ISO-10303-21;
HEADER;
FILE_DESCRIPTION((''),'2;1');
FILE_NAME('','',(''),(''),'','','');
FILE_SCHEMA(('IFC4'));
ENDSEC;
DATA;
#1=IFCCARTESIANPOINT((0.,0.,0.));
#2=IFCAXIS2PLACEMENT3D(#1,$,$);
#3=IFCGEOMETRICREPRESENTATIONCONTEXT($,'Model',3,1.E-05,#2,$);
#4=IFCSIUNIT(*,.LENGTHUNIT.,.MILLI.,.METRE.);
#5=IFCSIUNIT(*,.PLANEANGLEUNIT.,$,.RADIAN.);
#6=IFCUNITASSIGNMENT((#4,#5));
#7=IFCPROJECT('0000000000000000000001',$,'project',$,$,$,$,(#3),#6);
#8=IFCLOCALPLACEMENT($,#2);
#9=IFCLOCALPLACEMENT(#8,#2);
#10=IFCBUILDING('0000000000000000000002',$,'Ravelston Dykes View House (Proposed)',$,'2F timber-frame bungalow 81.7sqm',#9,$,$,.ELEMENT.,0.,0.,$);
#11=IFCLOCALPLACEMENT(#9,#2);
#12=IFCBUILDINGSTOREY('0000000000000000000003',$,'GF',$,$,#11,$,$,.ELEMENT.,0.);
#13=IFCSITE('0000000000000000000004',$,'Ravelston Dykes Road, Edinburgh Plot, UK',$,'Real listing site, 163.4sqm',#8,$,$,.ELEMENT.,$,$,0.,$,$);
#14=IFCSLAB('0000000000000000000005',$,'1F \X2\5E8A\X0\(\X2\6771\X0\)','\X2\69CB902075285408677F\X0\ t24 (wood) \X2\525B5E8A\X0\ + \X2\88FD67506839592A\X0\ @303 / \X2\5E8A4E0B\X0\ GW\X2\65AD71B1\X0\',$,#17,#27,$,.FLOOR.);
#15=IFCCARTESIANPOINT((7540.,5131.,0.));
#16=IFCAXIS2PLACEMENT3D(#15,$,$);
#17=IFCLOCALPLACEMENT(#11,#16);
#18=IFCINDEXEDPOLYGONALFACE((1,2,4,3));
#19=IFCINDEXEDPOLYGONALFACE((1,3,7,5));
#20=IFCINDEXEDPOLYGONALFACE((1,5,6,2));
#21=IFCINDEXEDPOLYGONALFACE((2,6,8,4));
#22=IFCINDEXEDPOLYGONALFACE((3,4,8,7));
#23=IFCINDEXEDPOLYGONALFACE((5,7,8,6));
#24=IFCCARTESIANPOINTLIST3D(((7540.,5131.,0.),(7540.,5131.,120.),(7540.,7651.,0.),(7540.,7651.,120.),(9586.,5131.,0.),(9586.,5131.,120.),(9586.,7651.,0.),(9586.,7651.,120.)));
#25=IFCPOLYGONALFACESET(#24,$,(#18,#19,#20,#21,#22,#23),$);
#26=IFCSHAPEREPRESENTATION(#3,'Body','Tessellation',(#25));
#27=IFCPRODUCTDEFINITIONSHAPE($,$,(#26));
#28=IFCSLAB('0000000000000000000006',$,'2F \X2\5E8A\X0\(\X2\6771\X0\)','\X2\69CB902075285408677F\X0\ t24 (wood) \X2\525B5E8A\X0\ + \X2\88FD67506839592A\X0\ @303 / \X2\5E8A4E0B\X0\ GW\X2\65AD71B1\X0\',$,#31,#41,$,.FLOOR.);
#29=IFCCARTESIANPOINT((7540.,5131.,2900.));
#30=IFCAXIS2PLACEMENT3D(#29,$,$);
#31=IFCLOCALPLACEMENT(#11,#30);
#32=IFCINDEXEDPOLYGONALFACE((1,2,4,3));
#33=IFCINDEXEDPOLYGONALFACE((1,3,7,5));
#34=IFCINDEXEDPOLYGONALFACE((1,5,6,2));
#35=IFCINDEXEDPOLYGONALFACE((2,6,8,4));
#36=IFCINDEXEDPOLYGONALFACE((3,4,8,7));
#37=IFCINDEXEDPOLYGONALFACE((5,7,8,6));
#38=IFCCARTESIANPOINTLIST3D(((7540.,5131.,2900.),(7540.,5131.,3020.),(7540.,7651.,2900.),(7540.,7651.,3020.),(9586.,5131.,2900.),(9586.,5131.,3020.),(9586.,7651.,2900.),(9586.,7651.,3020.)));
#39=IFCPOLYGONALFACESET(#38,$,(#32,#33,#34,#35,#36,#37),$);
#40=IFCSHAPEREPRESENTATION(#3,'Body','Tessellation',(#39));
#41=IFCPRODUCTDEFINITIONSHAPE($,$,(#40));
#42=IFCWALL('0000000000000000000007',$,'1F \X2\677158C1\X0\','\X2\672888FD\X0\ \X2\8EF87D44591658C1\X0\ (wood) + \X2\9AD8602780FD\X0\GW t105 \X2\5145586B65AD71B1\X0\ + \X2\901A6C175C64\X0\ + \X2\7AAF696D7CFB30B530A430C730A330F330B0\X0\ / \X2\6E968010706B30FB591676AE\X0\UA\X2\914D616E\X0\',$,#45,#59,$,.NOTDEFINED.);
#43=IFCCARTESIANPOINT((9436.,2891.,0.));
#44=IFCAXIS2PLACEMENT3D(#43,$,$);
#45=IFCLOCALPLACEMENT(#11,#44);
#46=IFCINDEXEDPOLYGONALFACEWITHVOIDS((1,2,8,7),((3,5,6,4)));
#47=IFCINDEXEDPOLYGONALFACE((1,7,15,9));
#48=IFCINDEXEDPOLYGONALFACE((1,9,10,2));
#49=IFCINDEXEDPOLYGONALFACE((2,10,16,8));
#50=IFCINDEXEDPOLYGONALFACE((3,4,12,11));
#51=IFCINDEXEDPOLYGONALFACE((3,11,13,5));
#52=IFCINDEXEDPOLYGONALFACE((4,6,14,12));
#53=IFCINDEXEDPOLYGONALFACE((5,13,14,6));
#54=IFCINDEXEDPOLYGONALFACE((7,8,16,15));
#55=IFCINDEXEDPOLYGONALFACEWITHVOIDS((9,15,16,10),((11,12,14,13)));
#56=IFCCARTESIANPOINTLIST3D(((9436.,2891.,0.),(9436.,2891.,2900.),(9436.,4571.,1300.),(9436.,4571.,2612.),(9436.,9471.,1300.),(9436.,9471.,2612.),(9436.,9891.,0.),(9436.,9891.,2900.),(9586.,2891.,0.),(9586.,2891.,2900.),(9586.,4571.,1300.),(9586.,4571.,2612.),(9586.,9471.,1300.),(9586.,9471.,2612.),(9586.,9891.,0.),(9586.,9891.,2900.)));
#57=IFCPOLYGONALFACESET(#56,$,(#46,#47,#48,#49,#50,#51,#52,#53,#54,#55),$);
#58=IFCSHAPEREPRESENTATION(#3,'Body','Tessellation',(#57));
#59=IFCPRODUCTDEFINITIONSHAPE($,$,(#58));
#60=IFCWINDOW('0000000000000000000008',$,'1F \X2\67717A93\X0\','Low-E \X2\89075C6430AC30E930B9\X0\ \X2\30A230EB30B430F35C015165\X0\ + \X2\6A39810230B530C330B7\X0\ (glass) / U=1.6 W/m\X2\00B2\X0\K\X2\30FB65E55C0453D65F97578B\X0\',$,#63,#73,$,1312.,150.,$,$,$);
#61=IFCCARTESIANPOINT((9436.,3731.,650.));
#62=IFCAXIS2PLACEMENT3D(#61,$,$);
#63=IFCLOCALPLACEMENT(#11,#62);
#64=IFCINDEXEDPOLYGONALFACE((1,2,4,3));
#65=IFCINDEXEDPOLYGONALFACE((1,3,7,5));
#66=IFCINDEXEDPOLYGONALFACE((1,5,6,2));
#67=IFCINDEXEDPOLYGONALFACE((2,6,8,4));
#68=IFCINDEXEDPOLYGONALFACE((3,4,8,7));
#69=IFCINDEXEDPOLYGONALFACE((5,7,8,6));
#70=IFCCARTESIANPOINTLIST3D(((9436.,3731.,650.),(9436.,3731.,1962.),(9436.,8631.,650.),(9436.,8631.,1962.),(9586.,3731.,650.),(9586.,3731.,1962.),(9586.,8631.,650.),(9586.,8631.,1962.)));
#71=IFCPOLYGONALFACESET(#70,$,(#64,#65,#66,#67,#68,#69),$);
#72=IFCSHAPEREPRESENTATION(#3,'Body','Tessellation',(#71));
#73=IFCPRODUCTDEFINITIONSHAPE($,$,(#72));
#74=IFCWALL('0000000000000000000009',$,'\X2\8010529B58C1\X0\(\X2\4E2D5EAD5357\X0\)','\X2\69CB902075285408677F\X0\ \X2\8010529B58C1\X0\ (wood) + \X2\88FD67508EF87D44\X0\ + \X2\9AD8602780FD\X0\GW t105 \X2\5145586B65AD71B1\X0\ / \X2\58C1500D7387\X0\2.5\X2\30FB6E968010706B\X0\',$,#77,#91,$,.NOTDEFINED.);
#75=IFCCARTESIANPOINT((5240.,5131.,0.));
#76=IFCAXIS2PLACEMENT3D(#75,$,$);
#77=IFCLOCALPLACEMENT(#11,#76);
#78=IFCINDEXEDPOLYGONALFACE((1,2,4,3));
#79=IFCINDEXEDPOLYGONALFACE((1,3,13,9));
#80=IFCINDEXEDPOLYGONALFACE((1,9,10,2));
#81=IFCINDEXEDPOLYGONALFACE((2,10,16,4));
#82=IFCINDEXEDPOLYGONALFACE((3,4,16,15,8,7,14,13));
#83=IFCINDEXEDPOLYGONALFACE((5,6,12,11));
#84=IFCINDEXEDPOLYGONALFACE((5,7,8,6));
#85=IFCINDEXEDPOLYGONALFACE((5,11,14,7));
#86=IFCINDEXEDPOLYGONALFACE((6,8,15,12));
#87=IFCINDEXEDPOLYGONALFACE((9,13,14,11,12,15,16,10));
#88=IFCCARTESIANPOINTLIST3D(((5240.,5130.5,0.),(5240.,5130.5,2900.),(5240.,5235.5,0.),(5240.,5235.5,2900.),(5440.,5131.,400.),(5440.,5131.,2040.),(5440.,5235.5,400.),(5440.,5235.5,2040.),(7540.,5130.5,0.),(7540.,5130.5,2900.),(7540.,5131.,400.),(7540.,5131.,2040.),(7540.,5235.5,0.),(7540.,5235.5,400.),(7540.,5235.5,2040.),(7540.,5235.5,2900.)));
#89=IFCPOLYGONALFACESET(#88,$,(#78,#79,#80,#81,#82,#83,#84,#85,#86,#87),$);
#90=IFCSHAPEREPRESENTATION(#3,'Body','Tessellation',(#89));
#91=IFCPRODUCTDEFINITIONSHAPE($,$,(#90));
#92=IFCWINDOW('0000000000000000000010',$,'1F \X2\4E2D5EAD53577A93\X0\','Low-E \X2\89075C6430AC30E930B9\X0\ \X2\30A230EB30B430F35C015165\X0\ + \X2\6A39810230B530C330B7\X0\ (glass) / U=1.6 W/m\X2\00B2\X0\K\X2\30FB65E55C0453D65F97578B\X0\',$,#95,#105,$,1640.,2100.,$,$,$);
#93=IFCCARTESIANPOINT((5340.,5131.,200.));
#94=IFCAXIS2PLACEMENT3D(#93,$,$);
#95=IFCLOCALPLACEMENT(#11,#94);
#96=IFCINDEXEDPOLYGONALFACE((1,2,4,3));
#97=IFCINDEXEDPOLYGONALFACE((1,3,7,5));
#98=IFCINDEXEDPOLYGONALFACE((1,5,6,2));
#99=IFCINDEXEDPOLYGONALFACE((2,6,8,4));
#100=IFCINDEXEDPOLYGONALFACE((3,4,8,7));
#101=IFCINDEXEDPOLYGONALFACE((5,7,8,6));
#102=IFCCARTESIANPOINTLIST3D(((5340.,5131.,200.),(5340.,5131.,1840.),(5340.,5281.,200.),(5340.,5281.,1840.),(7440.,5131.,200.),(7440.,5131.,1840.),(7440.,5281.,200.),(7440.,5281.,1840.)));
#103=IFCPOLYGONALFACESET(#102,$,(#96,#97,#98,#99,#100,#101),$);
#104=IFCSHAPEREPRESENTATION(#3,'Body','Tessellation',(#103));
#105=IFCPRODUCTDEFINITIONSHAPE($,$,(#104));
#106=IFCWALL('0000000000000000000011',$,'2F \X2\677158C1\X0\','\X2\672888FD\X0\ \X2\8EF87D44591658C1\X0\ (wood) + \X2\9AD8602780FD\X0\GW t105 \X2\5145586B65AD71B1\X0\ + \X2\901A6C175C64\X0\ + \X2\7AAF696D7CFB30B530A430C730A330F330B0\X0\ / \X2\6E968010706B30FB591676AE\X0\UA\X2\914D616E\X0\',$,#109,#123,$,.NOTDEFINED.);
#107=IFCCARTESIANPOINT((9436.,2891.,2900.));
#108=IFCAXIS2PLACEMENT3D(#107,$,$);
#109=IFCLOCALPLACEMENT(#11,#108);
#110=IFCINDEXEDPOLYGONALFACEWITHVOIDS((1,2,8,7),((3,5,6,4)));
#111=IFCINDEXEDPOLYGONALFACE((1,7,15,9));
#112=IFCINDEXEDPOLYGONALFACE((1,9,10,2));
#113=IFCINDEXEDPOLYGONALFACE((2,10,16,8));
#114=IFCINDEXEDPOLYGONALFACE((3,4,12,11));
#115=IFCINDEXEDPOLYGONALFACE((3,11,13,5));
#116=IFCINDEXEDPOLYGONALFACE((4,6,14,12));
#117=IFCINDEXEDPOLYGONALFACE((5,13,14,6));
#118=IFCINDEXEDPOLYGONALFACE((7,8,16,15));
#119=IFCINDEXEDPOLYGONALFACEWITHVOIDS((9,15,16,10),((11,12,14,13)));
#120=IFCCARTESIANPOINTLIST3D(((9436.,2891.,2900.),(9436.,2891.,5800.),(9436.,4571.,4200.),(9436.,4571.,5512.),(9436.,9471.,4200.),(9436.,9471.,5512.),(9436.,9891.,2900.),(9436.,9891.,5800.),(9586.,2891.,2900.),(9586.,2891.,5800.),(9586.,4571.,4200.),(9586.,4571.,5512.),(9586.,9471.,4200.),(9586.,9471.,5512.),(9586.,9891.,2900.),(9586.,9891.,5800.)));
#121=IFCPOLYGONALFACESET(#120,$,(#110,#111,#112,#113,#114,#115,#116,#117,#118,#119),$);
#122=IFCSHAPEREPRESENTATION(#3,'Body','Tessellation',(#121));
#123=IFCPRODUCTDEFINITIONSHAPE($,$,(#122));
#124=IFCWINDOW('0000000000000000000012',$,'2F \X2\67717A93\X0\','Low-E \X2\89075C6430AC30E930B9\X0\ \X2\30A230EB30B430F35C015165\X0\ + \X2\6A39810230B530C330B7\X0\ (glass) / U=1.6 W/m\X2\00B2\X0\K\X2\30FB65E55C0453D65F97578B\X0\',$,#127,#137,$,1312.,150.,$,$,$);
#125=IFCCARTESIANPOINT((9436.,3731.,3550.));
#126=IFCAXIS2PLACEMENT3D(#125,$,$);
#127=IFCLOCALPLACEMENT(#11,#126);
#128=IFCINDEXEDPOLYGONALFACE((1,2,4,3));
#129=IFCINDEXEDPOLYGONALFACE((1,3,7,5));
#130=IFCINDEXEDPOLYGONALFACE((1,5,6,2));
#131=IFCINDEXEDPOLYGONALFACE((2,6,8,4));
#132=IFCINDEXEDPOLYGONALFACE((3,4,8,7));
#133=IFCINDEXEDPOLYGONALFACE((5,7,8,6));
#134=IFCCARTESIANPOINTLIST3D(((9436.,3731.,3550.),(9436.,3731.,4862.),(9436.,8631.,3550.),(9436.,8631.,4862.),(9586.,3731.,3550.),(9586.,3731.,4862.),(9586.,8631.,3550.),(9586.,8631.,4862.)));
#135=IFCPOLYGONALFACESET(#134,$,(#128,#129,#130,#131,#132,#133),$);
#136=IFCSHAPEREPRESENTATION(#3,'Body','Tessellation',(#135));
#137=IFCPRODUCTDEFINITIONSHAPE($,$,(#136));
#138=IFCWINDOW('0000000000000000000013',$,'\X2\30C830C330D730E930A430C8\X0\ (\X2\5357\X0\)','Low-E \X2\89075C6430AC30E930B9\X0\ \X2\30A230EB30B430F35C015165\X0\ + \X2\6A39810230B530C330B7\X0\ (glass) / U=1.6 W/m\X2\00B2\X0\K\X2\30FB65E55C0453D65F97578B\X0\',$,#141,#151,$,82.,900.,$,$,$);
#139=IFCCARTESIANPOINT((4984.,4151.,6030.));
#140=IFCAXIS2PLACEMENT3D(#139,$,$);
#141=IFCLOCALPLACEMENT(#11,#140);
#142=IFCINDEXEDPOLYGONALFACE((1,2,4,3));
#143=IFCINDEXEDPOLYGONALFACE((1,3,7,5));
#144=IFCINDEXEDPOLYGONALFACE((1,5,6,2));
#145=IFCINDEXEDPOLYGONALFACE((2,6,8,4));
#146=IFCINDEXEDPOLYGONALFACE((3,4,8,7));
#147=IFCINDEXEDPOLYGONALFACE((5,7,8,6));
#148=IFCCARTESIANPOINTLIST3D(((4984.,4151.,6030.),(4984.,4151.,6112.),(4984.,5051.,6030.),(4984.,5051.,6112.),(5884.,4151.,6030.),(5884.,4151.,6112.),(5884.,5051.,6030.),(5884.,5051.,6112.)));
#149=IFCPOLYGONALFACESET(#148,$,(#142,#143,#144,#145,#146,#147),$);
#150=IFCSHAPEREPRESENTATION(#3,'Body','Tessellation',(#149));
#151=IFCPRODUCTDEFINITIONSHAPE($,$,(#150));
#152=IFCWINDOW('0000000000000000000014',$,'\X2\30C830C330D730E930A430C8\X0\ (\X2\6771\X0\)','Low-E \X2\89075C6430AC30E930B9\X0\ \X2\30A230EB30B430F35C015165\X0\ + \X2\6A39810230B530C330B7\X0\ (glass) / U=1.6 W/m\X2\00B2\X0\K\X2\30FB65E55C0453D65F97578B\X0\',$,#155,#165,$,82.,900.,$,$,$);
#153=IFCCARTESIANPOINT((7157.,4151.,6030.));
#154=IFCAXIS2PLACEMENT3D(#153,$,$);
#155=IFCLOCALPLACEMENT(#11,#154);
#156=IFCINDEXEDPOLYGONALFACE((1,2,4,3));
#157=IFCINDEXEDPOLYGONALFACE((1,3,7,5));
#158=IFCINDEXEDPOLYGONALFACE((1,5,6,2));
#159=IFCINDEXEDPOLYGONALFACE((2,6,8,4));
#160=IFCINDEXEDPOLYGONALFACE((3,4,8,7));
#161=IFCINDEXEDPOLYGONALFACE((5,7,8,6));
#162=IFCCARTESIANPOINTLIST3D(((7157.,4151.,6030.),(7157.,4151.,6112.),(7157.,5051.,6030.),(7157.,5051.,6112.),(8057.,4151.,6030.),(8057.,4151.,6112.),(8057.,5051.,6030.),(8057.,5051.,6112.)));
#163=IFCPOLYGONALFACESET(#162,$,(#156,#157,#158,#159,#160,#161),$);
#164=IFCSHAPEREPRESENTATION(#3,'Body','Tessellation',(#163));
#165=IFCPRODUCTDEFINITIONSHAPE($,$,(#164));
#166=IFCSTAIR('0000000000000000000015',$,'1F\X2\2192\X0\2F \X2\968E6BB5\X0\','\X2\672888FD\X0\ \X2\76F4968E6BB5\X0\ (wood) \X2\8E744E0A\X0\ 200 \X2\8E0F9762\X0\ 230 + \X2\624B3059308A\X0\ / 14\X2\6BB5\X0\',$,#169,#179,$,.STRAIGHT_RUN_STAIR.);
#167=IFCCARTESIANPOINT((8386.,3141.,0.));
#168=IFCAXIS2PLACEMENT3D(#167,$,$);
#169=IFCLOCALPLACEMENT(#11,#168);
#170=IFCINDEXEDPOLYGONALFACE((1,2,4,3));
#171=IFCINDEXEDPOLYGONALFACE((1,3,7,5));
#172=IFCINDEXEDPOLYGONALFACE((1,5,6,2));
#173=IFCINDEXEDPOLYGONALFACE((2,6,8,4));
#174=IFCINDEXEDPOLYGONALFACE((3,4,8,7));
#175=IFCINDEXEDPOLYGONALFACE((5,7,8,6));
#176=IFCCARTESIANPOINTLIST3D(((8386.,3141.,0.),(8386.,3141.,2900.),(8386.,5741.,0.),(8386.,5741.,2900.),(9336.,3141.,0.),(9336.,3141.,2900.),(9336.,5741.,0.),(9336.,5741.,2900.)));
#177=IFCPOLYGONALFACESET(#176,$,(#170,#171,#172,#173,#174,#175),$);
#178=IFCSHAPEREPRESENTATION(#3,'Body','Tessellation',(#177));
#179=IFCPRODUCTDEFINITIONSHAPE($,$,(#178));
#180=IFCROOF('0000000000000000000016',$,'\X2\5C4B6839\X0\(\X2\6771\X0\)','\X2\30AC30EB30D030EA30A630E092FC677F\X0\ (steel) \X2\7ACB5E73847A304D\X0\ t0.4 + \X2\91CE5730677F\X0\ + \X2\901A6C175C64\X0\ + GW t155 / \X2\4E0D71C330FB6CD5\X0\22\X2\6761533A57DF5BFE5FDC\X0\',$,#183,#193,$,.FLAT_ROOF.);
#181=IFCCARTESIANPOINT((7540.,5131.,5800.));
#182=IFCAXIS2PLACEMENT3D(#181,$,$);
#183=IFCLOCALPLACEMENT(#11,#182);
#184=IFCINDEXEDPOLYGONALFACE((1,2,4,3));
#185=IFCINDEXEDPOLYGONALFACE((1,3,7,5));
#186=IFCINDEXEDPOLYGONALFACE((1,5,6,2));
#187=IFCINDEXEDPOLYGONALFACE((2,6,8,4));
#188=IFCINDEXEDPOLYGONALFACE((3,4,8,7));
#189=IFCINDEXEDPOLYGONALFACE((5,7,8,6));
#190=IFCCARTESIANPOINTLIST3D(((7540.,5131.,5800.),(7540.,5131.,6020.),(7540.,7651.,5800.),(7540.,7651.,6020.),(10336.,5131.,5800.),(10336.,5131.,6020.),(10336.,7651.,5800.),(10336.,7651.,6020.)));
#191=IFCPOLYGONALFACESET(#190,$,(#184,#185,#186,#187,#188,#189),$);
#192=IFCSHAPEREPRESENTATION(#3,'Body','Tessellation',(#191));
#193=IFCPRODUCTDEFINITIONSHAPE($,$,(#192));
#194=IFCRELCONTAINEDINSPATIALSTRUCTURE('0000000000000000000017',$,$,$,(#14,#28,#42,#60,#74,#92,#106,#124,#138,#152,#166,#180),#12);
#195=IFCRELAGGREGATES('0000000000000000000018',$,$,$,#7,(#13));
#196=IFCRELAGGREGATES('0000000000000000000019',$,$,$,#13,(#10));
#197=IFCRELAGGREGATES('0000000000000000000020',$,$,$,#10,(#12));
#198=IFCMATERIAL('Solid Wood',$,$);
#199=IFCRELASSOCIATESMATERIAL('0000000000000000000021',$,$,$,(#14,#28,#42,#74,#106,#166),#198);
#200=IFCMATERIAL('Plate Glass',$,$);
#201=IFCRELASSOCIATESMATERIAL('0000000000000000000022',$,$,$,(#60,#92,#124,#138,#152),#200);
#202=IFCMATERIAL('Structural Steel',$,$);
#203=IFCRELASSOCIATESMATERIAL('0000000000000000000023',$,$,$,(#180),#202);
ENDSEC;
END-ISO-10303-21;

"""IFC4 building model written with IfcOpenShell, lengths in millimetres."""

from ifc_helpers import new_model, si_unit, frame, frame_2d, origin, place, context, project, spatial, rectangle, extrude, material, element, fill, save


model = new_model("IFC4")

# Units and contexts
model_context = context("Model", 3, precision=1e-05, world=origin())
ifc_project = project(units=[si_unit("LENGTHUNIT", "METRE", prefix="MILLI"), si_unit("PLANEANGLEUNIT", "RADIAN")], contexts=[model_context])

# Site, building, storey
site_placement = place(None, origin())
site = spatial("IfcSite", under=ifc_project, at=site_placement, Name="Ravelston Dykes Road, Edinburgh Plot, UK", ObjectType="Real listing site, 163.4sqm", CompositionType="ELEMENT", RefElevation=0.0)
building_placement = place(site_placement, origin())
building = spatial("IfcBuilding", under=site, at=building_placement, Name="Ravelston Dykes View House (Proposed)", ObjectType="2F timber-frame bungalow 81.7sqm", CompositionType="ELEMENT", ElevationOfRefHeight=0.0, ElevationOfTerrain=0.0)
storey_placement = place(building_placement, origin())
storey = spatial("IfcBuildingStorey", under=building, at=storey_placement, Name="GF", CompositionType="ELEMENT", Elevation=0.0)

# Slabs
ifc_material_1 = material(Name="Solid Wood")
slab_1_placement = place(storey_placement, frame((7540.0, 5131.0, 0.0)))
element("IfcSlab", 1, at=slab_1_placement, inside=storey, material=ifc_material_1, Name="1F 床(東)", Description="構造用合板 t24 (wood) 剛床 + 製材根太 @303 / 床下 GW断熱", PredefinedType="FLOOR", context=model_context, shape_type="SweptSolid", body=[
    extrude(rectangle(XDim=2046.0, YDim=2520.0, at=frame_2d((1023.0, 1260.0))), frame((7540.0, 5131.0, 0.0)), (0.0, 0.0, 1.0), 120.0),
])
slab_2_placement = place(storey_placement, frame((7540.0, 5131.0, 2900.0)))
element("IfcSlab", 2, at=slab_2_placement, inside=storey, material=ifc_material_1, Name="2F 床(東)", Description="構造用合板 t24 (wood) 剛床 + 製材根太 @303 / 床下 GW断熱", PredefinedType="FLOOR", context=model_context, shape_type="SweptSolid", body=[
    extrude(rectangle(XDim=2046.0, YDim=2520.0, at=frame_2d((1023.0, 1260.0))), frame((7540.0, 5131.0, 2900.0)), (0.0, 0.0, 1.0), 120.0),
])

# Walls, openings, windows
wall_1_placement = place(storey_placement, frame((9436.0, 2891.0, 0.0)))
wall_1 = element("IfcWall", 3, at=wall_1_placement, inside=storey, material=ifc_material_1, Name="1F 東壁", Description="木製 軸組外壁 (wood) + 高性能GW t105 充填断熱 + 通気層 + 窯業系サイディング / 準耐火・外皮UA配慮", PredefinedType="NOTDEFINED", context=model_context, shape_type="SweptSolid", body=[
    extrude(rectangle(XDim=150.0, YDim=7000.0, at=frame_2d((75.0, 3500.0))), frame((9436.0, 2891.0, 0.0)), (0.0, 0.0, 1.0), 2900.0),
])
opening_1_placement = place(storey_placement, frame((9436.0, 3731.0, 650.0)))
opening_1 = element("IfcOpeningElement", 4, at=opening_1_placement, cuts=wall_1, PredefinedType="NOTDEFINED", context=model_context, shape_type="SweptSolid", body=[
    extrude(rectangle(XDim=150.0, YDim=4900.0, at=frame_2d((75.0, 2450.0))), frame((9436.0, 3731.0, 650.0)), (0.0, 0.0, 1.0), 1312.0),
])
ifc_material_2 = material(Name="Plate Glass")
window_1_placement = place(storey_placement, frame((9436.0, 3731.0, 650.0)))
window_1 = element("IfcWindow", 5, at=window_1_placement, inside=storey, material=ifc_material_2, Name="1F 東窓", Description="Low-E 複層ガラス アルゴン封入 + 樹脂サッシ (glass) / U=1.6 W/m²K・日射取得型", OverallHeight=1312.0, OverallWidth=150.0, context=model_context, shape_type="SweptSolid", body=[
    extrude(rectangle(XDim=150.0, YDim=4900.0, at=frame_2d((75.0, 2450.0))), frame((9436.0, 3731.0, 650.0)), (0.0, 0.0, 1.0), 1312.0),
])
fill(opening_1, window_1)
wall_2_placement = place(storey_placement, frame((5240.0, 5131.0, 0.0)))
wall_2 = element("IfcWall", 6, at=wall_2_placement, inside=storey, material=ifc_material_1, Name="耐力壁(中庭南)", Description="構造用合板 耐力壁 (wood) + 製材軸組 + 高性能GW t105 充填断熱 / 壁倍率2.5・準耐火", PredefinedType="NOTDEFINED", context=model_context, shape_type="SweptSolid", body=[
    extrude(rectangle(XDim=2300.0, YDim=105.0, at=frame_2d((1150.0, 52.0))), frame((5240.0, 5131.0, 0.0)), (0.0, 0.0, 1.0), 2900.0),
])
opening_2_placement = place(storey_placement, frame((5340.0, 5131.0, 200.0)))
opening_2 = element("IfcOpeningElement", 7, at=opening_2_placement, cuts=wall_2, PredefinedType="NOTDEFINED", context=model_context, shape_type="SweptSolid", body=[
    extrude(rectangle(XDim=2100.0, YDim=150.0, at=frame_2d((1050.0, 75.0))), frame((5340.0, 5131.0, 200.0)), (0.0, 0.0, 1.0), 1640.0),
])
window_2_placement = place(storey_placement, frame((5340.0, 5131.0, 200.0)))
window_2 = element("IfcWindow", 8, at=window_2_placement, inside=storey, material=ifc_material_2, Name="1F 中庭南窓", Description="Low-E 複層ガラス アルゴン封入 + 樹脂サッシ (glass) / U=1.6 W/m²K・日射取得型", OverallHeight=1640.0, OverallWidth=2100.0, context=model_context, shape_type="SweptSolid", body=[
    extrude(rectangle(XDim=2100.0, YDim=150.0, at=frame_2d((1050.0, 75.0))), frame((5340.0, 5131.0, 200.0)), (0.0, 0.0, 1.0), 1640.0),
])
fill(opening_2, window_2)

# Wall, opening, window
wall_3_placement = place(storey_placement, frame((9436.0, 2891.0, 2900.0)))
wall_3 = element("IfcWall", 9, at=wall_3_placement, inside=storey, material=ifc_material_1, Name="2F 東壁", Description="木製 軸組外壁 (wood) + 高性能GW t105 充填断熱 + 通気層 + 窯業系サイディング / 準耐火・外皮UA配慮", PredefinedType="NOTDEFINED", context=model_context, shape_type="SweptSolid", body=[
    extrude(rectangle(XDim=150.0, YDim=7000.0, at=frame_2d((75.0, 3500.0))), frame((9436.0, 2891.0, 2900.0)), (0.0, 0.0, 1.0), 2900.0),
])
opening_3_placement = place(storey_placement, frame((9436.0, 3731.0, 3550.0)))
opening_3 = element("IfcOpeningElement", 10, at=opening_3_placement, cuts=wall_3, PredefinedType="NOTDEFINED", context=model_context, shape_type="SweptSolid", body=[
    extrude(rectangle(XDim=150.0, YDim=4900.0, at=frame_2d((75.0, 2450.0))), frame((9436.0, 3731.0, 3550.0)), (0.0, 0.0, 1.0), 1312.0),
])
window_3_placement = place(storey_placement, frame((9436.0, 3731.0, 3550.0)))
window_3 = element("IfcWindow", 11, at=window_3_placement, inside=storey, material=ifc_material_2, Name="2F 東窓", Description="Low-E 複層ガラス アルゴン封入 + 樹脂サッシ (glass) / U=1.6 W/m²K・日射取得型", OverallHeight=1312.0, OverallWidth=150.0, context=model_context, shape_type="SweptSolid", body=[
    extrude(rectangle(XDim=150.0, YDim=4900.0, at=frame_2d((75.0, 2450.0))), frame((9436.0, 3731.0, 3550.0)), (0.0, 0.0, 1.0), 1312.0),
])
fill(opening_3, window_3)

# Windows
window_4_placement = place(storey_placement, frame((4984.0, 4151.0, 6030.0)))
element("IfcWindow", 12, at=window_4_placement, inside=storey, material=ifc_material_2, Name="トップライト (南)", Description="Low-E 複層ガラス アルゴン封入 + 樹脂サッシ (glass) / U=1.6 W/m²K・日射取得型", OverallHeight=82.0, OverallWidth=900.0, context=model_context, shape_type="SweptSolid", body=[
    extrude(rectangle(XDim=900.0, YDim=900.0, at=frame_2d((450.0, 450.0))), frame((4984.0, 4151.0, 6030.0)), (0.0, 0.0, 1.0), 82.0),
])
window_5_placement = place(storey_placement, frame((7157.0, 4151.0, 6030.0)))
element("IfcWindow", 13, at=window_5_placement, inside=storey, material=ifc_material_2, Name="トップライト (東)", Description="Low-E 複層ガラス アルゴン封入 + 樹脂サッシ (glass) / U=1.6 W/m²K・日射取得型", OverallHeight=82.0, OverallWidth=900.0, context=model_context, shape_type="SweptSolid", body=[
    extrude(rectangle(XDim=900.0, YDim=900.0, at=frame_2d((450.0, 450.0))), frame((7157.0, 4151.0, 6030.0)), (0.0, 0.0, 1.0), 82.0),
])

# Stair
stair_placement = place(storey_placement, frame((8386.0, 3141.0, 0.0)))
element("IfcStair", 14, at=stair_placement, inside=storey, material=ifc_material_1, Name="1F→2F 階段", Description="木製 直階段 (wood) 蹴上 200 踏面 230 + 手すり / 14段", PredefinedType="STRAIGHT_RUN_STAIR", context=model_context, shape_type="SweptSolid", body=[
    extrude(rectangle(XDim=950.0, YDim=2600.0, at=frame_2d((475.0, 1300.0))), frame((8386.0, 3141.0, 0.0)), (0.0, 0.0, 1.0), 2900.0),
])

# Roof
ifc_material_3 = material(Name="Structural Steel")
roof_placement = place(storey_placement, frame((7540.0, 5131.0, 5800.0)))
element("IfcRoof", 15, at=roof_placement, inside=storey, material=ifc_material_3, Name="屋根(東)", Description="ガルバリウム鋼板 (steel) 立平葺き t0.4 + 野地板 + 通気層 + GW t155 / 不燃・法22条区域対応", PredefinedType="FLAT_ROOF", context=model_context, shape_type="SweptSolid", body=[
    extrude(rectangle(XDim=2796.0, YDim=2520.0, at=frame_2d((1398.0, 1260.0))), frame((7540.0, 5131.0, 5800.0)), (0.0, 0.0, 1.0), 220.0),
])

save(model, "model.ifc")
